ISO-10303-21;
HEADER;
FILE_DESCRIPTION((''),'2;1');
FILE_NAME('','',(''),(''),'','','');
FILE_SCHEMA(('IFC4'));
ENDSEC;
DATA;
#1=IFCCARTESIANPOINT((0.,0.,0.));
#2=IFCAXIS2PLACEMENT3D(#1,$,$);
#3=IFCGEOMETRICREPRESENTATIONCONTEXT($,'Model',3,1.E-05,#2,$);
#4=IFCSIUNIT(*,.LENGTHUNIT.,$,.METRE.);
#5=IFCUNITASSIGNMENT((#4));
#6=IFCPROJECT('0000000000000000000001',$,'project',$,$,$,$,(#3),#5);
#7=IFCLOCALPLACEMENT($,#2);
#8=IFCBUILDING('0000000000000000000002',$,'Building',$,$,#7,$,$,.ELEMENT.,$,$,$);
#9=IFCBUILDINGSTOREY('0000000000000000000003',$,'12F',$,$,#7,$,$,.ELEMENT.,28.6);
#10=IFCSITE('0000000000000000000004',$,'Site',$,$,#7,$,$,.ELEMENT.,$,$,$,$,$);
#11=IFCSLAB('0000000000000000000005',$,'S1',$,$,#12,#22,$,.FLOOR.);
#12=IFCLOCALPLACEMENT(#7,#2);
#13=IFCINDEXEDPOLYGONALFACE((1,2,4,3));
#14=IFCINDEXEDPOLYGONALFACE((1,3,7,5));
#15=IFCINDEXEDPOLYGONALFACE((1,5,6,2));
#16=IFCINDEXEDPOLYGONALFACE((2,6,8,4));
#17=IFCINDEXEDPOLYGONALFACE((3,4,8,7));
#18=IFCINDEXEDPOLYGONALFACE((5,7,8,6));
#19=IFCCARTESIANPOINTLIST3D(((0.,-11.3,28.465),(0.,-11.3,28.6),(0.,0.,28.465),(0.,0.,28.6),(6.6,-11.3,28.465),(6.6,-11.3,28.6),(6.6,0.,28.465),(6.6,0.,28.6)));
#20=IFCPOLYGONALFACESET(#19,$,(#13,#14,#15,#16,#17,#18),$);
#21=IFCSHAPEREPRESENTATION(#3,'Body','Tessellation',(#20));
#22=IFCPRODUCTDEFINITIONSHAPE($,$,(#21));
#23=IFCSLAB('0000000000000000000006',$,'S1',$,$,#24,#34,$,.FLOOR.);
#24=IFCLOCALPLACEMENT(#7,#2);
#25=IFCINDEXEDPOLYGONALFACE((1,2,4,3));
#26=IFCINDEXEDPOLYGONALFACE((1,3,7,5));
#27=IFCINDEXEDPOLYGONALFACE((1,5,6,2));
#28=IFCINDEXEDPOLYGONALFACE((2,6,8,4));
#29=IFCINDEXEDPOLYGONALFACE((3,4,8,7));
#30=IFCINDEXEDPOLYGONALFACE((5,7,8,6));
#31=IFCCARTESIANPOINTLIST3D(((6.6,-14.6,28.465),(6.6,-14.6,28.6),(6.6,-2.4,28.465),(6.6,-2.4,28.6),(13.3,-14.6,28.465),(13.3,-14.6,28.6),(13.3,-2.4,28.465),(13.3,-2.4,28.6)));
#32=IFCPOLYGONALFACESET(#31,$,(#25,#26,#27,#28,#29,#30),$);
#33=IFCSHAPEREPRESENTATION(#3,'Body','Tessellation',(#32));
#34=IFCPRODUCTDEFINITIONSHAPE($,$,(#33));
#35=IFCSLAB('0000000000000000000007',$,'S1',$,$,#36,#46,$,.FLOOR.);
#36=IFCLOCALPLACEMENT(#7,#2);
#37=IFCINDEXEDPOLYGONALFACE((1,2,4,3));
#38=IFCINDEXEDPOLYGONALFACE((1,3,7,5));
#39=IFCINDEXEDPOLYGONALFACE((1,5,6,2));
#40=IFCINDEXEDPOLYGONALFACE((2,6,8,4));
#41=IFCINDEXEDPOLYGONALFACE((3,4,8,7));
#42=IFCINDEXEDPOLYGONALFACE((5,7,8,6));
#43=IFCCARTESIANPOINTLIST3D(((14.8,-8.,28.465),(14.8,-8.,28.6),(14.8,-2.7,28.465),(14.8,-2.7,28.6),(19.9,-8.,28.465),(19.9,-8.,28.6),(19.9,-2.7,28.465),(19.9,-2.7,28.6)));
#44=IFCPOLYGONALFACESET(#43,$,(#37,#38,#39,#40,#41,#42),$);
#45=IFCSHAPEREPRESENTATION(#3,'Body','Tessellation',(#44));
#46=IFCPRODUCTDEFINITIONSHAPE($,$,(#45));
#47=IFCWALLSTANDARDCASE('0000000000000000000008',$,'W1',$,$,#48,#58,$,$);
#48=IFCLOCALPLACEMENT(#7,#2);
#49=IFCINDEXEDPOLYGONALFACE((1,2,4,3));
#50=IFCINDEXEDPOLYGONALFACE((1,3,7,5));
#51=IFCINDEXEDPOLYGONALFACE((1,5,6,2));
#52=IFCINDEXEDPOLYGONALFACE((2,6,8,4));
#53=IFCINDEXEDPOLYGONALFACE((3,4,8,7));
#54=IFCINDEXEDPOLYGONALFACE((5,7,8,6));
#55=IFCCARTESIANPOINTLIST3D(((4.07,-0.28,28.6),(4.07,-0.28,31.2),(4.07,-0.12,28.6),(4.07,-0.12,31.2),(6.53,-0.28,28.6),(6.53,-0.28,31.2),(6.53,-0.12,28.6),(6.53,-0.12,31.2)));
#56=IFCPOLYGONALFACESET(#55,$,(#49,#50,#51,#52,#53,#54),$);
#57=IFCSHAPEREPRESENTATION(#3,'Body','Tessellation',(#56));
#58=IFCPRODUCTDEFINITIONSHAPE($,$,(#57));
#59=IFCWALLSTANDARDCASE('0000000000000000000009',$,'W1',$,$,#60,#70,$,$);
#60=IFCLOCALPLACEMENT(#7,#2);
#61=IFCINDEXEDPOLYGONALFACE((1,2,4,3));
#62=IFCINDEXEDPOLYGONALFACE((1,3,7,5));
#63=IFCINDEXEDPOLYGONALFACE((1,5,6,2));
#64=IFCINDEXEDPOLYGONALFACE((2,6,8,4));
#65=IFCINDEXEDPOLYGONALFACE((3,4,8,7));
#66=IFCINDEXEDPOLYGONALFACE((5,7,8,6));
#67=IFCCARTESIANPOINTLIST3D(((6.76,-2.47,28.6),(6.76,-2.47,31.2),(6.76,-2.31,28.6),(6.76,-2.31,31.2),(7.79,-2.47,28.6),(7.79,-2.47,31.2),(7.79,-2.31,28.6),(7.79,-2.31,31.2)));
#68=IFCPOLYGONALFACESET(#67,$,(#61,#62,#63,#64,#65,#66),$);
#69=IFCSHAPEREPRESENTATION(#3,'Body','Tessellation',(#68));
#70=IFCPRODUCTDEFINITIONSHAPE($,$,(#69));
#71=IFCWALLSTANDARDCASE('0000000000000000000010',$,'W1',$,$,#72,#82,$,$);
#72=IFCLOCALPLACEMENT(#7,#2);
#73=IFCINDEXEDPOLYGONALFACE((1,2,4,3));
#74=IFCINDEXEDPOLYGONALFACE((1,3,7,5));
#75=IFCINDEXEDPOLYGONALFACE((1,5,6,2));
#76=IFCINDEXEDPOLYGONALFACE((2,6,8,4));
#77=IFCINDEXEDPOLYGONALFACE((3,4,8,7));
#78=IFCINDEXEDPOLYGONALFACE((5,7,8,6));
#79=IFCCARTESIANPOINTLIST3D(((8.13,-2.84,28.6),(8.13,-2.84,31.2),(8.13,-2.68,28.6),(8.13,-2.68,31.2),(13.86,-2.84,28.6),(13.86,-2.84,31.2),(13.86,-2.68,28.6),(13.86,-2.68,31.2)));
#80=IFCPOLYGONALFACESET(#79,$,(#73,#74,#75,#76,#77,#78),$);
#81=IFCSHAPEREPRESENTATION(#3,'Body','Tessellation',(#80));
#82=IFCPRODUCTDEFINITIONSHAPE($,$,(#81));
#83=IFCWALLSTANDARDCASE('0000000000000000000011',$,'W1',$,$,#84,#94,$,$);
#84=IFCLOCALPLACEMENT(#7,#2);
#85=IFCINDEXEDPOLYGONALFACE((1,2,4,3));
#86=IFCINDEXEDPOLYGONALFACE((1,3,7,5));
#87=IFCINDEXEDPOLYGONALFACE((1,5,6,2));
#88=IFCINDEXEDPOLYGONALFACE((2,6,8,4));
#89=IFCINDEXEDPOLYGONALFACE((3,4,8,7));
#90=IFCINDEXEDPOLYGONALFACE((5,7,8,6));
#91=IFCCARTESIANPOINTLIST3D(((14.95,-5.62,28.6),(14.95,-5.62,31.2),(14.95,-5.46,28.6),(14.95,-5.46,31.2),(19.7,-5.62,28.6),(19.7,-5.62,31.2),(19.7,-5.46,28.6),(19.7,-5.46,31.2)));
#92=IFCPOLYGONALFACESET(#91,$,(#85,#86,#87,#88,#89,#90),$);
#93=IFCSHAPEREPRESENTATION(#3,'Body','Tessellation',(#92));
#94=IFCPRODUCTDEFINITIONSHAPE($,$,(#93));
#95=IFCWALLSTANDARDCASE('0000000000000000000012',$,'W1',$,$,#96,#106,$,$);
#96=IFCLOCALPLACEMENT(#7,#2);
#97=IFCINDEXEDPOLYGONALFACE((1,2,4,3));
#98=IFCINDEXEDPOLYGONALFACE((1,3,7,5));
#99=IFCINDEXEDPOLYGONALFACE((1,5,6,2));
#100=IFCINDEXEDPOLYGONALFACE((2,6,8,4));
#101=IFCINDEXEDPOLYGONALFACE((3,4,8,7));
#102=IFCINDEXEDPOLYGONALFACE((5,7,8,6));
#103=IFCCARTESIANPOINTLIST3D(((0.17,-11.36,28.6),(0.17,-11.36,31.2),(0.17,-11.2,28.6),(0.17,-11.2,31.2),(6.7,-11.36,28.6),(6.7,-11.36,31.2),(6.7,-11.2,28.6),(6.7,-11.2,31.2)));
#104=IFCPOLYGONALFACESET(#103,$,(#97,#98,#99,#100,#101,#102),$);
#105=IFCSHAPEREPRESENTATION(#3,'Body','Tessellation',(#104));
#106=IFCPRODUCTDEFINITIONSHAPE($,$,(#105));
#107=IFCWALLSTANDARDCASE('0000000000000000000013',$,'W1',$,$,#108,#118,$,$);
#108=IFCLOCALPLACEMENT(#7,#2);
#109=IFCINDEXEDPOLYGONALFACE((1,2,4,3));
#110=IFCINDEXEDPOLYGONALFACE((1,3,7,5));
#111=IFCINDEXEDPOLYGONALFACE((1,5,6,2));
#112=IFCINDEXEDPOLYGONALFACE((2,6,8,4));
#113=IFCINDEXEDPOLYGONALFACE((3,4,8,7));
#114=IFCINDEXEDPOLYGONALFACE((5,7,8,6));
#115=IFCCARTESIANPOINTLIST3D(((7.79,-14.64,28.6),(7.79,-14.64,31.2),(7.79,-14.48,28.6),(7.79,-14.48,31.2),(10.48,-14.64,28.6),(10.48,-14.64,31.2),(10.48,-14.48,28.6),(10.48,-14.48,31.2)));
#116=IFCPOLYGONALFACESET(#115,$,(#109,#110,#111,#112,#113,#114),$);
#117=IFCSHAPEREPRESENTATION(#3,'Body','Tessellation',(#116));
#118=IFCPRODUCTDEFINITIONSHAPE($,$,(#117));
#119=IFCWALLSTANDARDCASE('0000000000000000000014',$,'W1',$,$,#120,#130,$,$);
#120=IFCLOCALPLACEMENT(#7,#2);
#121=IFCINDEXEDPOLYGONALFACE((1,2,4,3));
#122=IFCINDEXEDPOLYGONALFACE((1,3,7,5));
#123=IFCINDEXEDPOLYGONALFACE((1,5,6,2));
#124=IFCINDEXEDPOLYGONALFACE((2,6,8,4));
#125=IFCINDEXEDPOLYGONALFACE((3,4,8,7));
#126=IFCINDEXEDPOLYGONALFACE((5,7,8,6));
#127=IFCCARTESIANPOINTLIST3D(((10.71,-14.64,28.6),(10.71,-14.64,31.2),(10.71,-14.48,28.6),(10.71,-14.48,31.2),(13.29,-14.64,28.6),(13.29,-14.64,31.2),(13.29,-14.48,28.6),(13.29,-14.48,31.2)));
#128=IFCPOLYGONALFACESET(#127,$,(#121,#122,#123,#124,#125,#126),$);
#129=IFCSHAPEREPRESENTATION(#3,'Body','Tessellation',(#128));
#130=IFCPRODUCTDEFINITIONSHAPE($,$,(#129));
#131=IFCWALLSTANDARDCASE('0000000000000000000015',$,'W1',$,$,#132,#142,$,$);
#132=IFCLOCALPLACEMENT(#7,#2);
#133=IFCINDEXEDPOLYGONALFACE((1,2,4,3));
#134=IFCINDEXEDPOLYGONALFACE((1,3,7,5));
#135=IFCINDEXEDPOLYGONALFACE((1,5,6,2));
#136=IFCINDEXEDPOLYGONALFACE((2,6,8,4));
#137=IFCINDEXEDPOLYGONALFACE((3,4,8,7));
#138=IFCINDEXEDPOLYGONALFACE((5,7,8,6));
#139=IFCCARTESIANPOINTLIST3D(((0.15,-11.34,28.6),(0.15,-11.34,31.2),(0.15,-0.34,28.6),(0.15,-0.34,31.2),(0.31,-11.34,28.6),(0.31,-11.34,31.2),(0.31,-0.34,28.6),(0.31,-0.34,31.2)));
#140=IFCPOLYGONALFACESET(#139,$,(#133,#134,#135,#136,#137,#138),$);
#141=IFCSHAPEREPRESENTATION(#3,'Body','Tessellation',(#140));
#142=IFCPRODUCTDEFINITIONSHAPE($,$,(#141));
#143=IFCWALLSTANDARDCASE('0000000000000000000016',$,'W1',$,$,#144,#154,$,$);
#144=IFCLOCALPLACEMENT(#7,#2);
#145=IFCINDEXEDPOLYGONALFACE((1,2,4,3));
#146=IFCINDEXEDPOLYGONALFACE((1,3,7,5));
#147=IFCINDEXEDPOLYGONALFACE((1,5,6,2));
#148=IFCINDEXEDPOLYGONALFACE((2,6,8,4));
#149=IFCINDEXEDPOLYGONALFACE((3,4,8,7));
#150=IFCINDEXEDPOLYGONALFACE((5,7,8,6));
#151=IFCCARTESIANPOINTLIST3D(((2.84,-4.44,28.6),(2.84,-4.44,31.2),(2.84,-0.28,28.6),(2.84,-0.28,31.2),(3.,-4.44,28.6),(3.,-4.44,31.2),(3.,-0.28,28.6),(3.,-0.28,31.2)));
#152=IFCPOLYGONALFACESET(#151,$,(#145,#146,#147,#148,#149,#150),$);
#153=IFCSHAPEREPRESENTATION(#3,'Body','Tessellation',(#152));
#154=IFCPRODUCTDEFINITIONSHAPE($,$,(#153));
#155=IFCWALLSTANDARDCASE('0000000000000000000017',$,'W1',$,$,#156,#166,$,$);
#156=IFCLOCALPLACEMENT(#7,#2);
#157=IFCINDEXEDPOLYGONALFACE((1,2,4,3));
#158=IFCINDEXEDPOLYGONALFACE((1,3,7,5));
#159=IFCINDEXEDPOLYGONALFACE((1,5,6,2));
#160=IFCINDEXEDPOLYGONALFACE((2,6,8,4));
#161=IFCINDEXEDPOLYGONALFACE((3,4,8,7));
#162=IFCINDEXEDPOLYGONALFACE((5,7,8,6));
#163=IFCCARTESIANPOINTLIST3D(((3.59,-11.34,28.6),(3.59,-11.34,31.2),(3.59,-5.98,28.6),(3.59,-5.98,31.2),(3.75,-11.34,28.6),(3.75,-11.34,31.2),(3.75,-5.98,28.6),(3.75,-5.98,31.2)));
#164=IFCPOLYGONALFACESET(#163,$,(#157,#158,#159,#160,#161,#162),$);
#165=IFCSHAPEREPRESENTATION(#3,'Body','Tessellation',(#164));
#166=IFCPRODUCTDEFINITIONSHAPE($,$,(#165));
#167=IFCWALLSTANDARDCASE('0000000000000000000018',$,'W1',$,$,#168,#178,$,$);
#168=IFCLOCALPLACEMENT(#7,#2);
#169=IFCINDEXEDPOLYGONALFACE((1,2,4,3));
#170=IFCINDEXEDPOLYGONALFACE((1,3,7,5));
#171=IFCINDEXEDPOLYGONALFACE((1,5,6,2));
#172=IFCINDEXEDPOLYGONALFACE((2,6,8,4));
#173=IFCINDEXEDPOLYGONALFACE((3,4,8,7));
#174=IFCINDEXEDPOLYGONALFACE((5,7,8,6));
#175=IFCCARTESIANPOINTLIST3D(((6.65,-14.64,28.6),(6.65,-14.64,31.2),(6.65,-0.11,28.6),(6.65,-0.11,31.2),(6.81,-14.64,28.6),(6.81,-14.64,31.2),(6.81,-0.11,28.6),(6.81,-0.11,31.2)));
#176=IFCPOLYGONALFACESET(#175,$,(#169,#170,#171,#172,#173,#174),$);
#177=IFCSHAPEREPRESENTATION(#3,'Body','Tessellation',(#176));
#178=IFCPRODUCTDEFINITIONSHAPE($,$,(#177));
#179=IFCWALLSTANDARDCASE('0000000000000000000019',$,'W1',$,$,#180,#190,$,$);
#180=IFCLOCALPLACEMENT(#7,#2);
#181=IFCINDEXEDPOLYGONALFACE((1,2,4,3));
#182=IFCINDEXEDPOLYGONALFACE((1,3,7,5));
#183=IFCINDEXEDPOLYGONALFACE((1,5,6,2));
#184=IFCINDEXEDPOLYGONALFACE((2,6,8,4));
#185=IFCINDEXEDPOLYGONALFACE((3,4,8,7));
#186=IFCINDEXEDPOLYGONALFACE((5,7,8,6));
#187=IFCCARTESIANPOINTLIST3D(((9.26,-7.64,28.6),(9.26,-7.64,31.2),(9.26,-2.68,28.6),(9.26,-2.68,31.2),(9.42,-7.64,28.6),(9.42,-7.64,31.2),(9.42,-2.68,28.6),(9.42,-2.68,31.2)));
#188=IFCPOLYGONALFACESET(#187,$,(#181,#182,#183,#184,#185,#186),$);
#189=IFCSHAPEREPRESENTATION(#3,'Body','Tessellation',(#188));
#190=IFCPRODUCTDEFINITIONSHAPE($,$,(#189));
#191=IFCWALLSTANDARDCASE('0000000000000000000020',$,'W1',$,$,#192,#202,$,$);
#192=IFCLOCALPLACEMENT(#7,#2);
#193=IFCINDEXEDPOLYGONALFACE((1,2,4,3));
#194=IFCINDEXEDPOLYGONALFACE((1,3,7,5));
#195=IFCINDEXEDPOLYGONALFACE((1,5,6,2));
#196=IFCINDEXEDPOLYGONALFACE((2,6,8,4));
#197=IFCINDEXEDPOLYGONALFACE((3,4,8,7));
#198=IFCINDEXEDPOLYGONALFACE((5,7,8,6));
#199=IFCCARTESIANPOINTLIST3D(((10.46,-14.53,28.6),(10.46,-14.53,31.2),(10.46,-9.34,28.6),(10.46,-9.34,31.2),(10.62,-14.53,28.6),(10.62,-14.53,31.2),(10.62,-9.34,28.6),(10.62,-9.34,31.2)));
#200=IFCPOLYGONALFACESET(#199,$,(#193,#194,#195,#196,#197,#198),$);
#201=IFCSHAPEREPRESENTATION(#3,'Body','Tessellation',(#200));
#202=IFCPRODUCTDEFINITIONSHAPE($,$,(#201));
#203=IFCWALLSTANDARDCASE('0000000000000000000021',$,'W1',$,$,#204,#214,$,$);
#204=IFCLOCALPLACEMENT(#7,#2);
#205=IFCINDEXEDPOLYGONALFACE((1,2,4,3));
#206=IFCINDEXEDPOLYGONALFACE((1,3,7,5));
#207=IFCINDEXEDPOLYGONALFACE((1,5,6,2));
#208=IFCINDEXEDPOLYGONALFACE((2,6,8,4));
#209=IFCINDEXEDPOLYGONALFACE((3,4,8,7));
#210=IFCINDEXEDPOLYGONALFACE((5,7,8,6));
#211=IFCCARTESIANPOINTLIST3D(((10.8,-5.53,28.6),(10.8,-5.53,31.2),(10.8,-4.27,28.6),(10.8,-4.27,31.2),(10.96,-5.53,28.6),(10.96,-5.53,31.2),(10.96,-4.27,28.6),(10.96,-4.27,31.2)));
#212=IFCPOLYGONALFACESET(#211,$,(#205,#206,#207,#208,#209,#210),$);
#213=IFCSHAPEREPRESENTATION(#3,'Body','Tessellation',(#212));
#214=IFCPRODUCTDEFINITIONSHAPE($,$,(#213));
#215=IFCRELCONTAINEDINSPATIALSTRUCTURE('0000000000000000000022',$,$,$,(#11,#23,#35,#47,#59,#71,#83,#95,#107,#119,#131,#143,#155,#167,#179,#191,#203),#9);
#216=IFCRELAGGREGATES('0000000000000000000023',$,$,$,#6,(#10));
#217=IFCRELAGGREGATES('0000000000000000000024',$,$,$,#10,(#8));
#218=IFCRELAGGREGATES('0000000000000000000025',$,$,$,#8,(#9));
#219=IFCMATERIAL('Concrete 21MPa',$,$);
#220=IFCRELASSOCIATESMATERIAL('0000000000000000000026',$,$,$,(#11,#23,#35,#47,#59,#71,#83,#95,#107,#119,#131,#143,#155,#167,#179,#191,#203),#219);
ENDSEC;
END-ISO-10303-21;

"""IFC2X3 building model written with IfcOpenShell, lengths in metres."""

from ifc_helpers import new_model, si_unit, frame, origin, origin_2d, place, context, project, spatial, rectangle, extrude, material, element, save


model = new_model("IFC2X3")

# Units and contexts
model_context = context("Model", 3, precision=1e-05, world=origin())
ifc_project = project(units=[si_unit("LENGTHUNIT", "METRE")], contexts=[model_context])

# Site, building, storey
placement = place(None, origin())
site = spatial("IfcSite", under=ifc_project, at=placement, Name="Site", CompositionType="ELEMENT")
building = spatial("IfcBuilding", under=site, at=placement, Name="Building", CompositionType="ELEMENT")
storey = spatial("IfcBuildingStorey", under=building, at=placement, Name="12F", CompositionType="ELEMENT", Elevation=28.6)

# Slabs
ifc_material_1 = material(Name="Concrete 21MPa")
slab_1_placement = place(None, frame((3.3, -5.65, 28.465)))
element("IfcSlab", 1, at=slab_1_placement, inside=storey, material=ifc_material_1, Name="S1", PredefinedType="FLOOR", context=model_context, shape_type="SweptSolid", body=[
    extrude(rectangle(XDim=6.6, YDim=11.3, at=origin_2d()), origin(), (0.0, 0.0, 1.0), 0.135),
])
slab_2_placement = place(None, frame((9.95, -8.5, 28.465)))
element("IfcSlab", 2, at=slab_2_placement, inside=storey, material=ifc_material_1, Name="S1", PredefinedType="FLOOR", context=model_context, shape_type="SweptSolid", body=[
    extrude(rectangle(XDim=6.7, YDim=12.2, at=origin_2d()), origin(), (0.0, 0.0, 1.0), 0.135),
])
slab_3_placement = place(None, frame((17.35, -5.35, 28.465)))
element("IfcSlab", 3, at=slab_3_placement, inside=storey, material=ifc_material_1, Name="S1", PredefinedType="FLOOR", context=model_context, shape_type="SweptSolid", body=[
    extrude(rectangle(XDim=5.1, YDim=5.3, at=origin_2d()), origin(), (0.0, 0.0, 1.0), 0.135),
])

# Walls
wall_1_placement = place(None, frame((5.3, -0.2, 28.6)))
element("IfcWallStandardCase", 4, at=wall_1_placement, inside=storey, material=ifc_material_1, Name="W1", context=model_context, shape_type="SweptSolid", body=[
    extrude(rectangle(XDim=2.46, YDim=0.16, at=origin_2d()), origin(), (0.0, 0.0, 1.0), 2.6),
])
wall_2_placement = place(None, frame((7.275, -2.39, 28.6)))
element("IfcWallStandardCase", 5, at=wall_2_placement, inside=storey, material=ifc_material_1, Name="W1", context=model_context, shape_type="SweptSolid", body=[
    extrude(rectangle(XDim=1.03, YDim=0.16, at=origin_2d()), origin(), (0.0, 0.0, 1.0), 2.6),
])
wall_3_placement = place(None, frame((10.995, -2.76, 28.6)))
element("IfcWallStandardCase", 6, at=wall_3_placement, inside=storey, material=ifc_material_1, Name="W1", context=model_context, shape_type="SweptSolid", body=[
    extrude(rectangle(XDim=5.73, YDim=0.16, at=origin_2d()), origin(), (0.0, 0.0, 1.0), 2.6),
])
wall_4_placement = place(None, frame((17.325, -5.54, 28.6)))
element("IfcWallStandardCase", 7, at=wall_4_placement, inside=storey, material=ifc_material_1, Name="W1", context=model_context, shape_type="SweptSolid", body=[
    extrude(rectangle(XDim=4.75, YDim=0.16, at=origin_2d()), origin(), (0.0, 0.0, 1.0), 2.6),
])
wall_5_placement = place(None, frame((3.435, -11.28, 28.6)))
element("IfcWallStandardCase", 8, at=wall_5_placement, inside=storey, material=ifc_material_1, Name="W1", context=model_context, shape_type="SweptSolid", body=[
    extrude(rectangle(XDim=6.53, YDim=0.16, at=origin_2d()), origin(), (0.0, 0.0, 1.0), 2.6),
])
wall_6_placement = place(None, frame((9.135, -14.56, 28.6)))
element("IfcWallStandardCase", 9, at=wall_6_placement, inside=storey, material=ifc_material_1, Name="W1", context=model_context, shape_type="SweptSolid", body=[
    extrude(rectangle(XDim=2.69, YDim=0.16, at=origin_2d()), origin(), (0.0, 0.0, 1.0), 2.6),
])
wall_7_placement = place(None, frame((12.0, -14.56, 28.6)))
element("IfcWallStandardCase", 10, at=wall_7_placement, inside=storey, material=ifc_material_1, Name="W1", context=model_context, shape_type="SweptSolid", body=[
    extrude(rectangle(XDim=2.58, YDim=0.16, at=origin_2d()), origin(), (0.0, 0.0, 1.0), 2.6),
])
wall_8_placement = place(None, frame((0.23, -5.84, 28.6)))
element("IfcWallStandardCase", 11, at=wall_8_placement, inside=storey, material=ifc_material_1, Name="W1", context=model_context, shape_type="SweptSolid", body=[
    extrude(rectangle(XDim=0.16, YDim=11.0, at=origin_2d()), origin(), (0.0, 0.0, 1.0), 2.6),
])
wall_9_placement = place(None, frame((2.92, -2.36, 28.6)))
element("IfcWallStandardCase", 12, at=wall_9_placement, inside=storey, material=ifc_material_1, Name="W1", context=model_context, shape_type="SweptSolid", body=[
    extrude(rectangle(XDim=0.16, YDim=4.16, at=origin_2d()), origin(), (0.0, 0.0, 1.0), 2.6),
])
wall_10_placement = place(None, frame((3.67, -8.66, 28.6)))
element("IfcWallStandardCase", 13, at=wall_10_placement, inside=storey, material=ifc_material_1, Name="W1", context=model_context, shape_type="SweptSolid", body=[
    extrude(rectangle(XDim=0.16, YDim=5.36, at=origin_2d()), origin(), (0.0, 0.0, 1.0), 2.6),
])
wall_11_placement = place(None, frame((6.73, -7.375, 28.6)))
element("IfcWallStandardCase", 14, at=wall_11_placement, inside=storey, material=ifc_material_1, Name="W1", context=model_context, shape_type="SweptSolid", body=[
    extrude(rectangle(XDim=0.16, YDim=14.53, at=origin_2d()), origin(), (0.0, 0.0, 1.0), 2.6),
])
wall_12_placement = place(None, frame((9.34, -5.16, 28.6)))
element("IfcWallStandardCase", 15, at=wall_12_placement, inside=storey, material=ifc_material_1, Name="W1", context=model_context, shape_type="SweptSolid", body=[
    extrude(rectangle(XDim=0.16, YDim=4.96, at=origin_2d()), origin(), (0.0, 0.0, 1.0), 2.6),
])
wall_13_placement = place(None, frame((10.54, -11.935, 28.6)))
element("IfcWallStandardCase", 16, at=wall_13_placement, inside=storey, material=ifc_material_1, Name="W1", context=model_context, shape_type="SweptSolid", body=[
    extrude(rectangle(XDim=0.16, YDim=5.19, at=origin_2d()), origin(), (0.0, 0.0, 1.0), 2.6),
])
wall_14_placement = place(None, frame((10.88, -4.9, 28.6)))
element("IfcWallStandardCase", 17, at=wall_14_placement, inside=storey, material=ifc_material_1, Name="W1", context=model_context, shape_type="SweptSolid", body=[
    extrude(rectangle(XDim=0.16, YDim=1.26, at=origin_2d()), origin(), (0.0, 0.0, 1.0), 2.6),
])

save(model, "model.ifc")
